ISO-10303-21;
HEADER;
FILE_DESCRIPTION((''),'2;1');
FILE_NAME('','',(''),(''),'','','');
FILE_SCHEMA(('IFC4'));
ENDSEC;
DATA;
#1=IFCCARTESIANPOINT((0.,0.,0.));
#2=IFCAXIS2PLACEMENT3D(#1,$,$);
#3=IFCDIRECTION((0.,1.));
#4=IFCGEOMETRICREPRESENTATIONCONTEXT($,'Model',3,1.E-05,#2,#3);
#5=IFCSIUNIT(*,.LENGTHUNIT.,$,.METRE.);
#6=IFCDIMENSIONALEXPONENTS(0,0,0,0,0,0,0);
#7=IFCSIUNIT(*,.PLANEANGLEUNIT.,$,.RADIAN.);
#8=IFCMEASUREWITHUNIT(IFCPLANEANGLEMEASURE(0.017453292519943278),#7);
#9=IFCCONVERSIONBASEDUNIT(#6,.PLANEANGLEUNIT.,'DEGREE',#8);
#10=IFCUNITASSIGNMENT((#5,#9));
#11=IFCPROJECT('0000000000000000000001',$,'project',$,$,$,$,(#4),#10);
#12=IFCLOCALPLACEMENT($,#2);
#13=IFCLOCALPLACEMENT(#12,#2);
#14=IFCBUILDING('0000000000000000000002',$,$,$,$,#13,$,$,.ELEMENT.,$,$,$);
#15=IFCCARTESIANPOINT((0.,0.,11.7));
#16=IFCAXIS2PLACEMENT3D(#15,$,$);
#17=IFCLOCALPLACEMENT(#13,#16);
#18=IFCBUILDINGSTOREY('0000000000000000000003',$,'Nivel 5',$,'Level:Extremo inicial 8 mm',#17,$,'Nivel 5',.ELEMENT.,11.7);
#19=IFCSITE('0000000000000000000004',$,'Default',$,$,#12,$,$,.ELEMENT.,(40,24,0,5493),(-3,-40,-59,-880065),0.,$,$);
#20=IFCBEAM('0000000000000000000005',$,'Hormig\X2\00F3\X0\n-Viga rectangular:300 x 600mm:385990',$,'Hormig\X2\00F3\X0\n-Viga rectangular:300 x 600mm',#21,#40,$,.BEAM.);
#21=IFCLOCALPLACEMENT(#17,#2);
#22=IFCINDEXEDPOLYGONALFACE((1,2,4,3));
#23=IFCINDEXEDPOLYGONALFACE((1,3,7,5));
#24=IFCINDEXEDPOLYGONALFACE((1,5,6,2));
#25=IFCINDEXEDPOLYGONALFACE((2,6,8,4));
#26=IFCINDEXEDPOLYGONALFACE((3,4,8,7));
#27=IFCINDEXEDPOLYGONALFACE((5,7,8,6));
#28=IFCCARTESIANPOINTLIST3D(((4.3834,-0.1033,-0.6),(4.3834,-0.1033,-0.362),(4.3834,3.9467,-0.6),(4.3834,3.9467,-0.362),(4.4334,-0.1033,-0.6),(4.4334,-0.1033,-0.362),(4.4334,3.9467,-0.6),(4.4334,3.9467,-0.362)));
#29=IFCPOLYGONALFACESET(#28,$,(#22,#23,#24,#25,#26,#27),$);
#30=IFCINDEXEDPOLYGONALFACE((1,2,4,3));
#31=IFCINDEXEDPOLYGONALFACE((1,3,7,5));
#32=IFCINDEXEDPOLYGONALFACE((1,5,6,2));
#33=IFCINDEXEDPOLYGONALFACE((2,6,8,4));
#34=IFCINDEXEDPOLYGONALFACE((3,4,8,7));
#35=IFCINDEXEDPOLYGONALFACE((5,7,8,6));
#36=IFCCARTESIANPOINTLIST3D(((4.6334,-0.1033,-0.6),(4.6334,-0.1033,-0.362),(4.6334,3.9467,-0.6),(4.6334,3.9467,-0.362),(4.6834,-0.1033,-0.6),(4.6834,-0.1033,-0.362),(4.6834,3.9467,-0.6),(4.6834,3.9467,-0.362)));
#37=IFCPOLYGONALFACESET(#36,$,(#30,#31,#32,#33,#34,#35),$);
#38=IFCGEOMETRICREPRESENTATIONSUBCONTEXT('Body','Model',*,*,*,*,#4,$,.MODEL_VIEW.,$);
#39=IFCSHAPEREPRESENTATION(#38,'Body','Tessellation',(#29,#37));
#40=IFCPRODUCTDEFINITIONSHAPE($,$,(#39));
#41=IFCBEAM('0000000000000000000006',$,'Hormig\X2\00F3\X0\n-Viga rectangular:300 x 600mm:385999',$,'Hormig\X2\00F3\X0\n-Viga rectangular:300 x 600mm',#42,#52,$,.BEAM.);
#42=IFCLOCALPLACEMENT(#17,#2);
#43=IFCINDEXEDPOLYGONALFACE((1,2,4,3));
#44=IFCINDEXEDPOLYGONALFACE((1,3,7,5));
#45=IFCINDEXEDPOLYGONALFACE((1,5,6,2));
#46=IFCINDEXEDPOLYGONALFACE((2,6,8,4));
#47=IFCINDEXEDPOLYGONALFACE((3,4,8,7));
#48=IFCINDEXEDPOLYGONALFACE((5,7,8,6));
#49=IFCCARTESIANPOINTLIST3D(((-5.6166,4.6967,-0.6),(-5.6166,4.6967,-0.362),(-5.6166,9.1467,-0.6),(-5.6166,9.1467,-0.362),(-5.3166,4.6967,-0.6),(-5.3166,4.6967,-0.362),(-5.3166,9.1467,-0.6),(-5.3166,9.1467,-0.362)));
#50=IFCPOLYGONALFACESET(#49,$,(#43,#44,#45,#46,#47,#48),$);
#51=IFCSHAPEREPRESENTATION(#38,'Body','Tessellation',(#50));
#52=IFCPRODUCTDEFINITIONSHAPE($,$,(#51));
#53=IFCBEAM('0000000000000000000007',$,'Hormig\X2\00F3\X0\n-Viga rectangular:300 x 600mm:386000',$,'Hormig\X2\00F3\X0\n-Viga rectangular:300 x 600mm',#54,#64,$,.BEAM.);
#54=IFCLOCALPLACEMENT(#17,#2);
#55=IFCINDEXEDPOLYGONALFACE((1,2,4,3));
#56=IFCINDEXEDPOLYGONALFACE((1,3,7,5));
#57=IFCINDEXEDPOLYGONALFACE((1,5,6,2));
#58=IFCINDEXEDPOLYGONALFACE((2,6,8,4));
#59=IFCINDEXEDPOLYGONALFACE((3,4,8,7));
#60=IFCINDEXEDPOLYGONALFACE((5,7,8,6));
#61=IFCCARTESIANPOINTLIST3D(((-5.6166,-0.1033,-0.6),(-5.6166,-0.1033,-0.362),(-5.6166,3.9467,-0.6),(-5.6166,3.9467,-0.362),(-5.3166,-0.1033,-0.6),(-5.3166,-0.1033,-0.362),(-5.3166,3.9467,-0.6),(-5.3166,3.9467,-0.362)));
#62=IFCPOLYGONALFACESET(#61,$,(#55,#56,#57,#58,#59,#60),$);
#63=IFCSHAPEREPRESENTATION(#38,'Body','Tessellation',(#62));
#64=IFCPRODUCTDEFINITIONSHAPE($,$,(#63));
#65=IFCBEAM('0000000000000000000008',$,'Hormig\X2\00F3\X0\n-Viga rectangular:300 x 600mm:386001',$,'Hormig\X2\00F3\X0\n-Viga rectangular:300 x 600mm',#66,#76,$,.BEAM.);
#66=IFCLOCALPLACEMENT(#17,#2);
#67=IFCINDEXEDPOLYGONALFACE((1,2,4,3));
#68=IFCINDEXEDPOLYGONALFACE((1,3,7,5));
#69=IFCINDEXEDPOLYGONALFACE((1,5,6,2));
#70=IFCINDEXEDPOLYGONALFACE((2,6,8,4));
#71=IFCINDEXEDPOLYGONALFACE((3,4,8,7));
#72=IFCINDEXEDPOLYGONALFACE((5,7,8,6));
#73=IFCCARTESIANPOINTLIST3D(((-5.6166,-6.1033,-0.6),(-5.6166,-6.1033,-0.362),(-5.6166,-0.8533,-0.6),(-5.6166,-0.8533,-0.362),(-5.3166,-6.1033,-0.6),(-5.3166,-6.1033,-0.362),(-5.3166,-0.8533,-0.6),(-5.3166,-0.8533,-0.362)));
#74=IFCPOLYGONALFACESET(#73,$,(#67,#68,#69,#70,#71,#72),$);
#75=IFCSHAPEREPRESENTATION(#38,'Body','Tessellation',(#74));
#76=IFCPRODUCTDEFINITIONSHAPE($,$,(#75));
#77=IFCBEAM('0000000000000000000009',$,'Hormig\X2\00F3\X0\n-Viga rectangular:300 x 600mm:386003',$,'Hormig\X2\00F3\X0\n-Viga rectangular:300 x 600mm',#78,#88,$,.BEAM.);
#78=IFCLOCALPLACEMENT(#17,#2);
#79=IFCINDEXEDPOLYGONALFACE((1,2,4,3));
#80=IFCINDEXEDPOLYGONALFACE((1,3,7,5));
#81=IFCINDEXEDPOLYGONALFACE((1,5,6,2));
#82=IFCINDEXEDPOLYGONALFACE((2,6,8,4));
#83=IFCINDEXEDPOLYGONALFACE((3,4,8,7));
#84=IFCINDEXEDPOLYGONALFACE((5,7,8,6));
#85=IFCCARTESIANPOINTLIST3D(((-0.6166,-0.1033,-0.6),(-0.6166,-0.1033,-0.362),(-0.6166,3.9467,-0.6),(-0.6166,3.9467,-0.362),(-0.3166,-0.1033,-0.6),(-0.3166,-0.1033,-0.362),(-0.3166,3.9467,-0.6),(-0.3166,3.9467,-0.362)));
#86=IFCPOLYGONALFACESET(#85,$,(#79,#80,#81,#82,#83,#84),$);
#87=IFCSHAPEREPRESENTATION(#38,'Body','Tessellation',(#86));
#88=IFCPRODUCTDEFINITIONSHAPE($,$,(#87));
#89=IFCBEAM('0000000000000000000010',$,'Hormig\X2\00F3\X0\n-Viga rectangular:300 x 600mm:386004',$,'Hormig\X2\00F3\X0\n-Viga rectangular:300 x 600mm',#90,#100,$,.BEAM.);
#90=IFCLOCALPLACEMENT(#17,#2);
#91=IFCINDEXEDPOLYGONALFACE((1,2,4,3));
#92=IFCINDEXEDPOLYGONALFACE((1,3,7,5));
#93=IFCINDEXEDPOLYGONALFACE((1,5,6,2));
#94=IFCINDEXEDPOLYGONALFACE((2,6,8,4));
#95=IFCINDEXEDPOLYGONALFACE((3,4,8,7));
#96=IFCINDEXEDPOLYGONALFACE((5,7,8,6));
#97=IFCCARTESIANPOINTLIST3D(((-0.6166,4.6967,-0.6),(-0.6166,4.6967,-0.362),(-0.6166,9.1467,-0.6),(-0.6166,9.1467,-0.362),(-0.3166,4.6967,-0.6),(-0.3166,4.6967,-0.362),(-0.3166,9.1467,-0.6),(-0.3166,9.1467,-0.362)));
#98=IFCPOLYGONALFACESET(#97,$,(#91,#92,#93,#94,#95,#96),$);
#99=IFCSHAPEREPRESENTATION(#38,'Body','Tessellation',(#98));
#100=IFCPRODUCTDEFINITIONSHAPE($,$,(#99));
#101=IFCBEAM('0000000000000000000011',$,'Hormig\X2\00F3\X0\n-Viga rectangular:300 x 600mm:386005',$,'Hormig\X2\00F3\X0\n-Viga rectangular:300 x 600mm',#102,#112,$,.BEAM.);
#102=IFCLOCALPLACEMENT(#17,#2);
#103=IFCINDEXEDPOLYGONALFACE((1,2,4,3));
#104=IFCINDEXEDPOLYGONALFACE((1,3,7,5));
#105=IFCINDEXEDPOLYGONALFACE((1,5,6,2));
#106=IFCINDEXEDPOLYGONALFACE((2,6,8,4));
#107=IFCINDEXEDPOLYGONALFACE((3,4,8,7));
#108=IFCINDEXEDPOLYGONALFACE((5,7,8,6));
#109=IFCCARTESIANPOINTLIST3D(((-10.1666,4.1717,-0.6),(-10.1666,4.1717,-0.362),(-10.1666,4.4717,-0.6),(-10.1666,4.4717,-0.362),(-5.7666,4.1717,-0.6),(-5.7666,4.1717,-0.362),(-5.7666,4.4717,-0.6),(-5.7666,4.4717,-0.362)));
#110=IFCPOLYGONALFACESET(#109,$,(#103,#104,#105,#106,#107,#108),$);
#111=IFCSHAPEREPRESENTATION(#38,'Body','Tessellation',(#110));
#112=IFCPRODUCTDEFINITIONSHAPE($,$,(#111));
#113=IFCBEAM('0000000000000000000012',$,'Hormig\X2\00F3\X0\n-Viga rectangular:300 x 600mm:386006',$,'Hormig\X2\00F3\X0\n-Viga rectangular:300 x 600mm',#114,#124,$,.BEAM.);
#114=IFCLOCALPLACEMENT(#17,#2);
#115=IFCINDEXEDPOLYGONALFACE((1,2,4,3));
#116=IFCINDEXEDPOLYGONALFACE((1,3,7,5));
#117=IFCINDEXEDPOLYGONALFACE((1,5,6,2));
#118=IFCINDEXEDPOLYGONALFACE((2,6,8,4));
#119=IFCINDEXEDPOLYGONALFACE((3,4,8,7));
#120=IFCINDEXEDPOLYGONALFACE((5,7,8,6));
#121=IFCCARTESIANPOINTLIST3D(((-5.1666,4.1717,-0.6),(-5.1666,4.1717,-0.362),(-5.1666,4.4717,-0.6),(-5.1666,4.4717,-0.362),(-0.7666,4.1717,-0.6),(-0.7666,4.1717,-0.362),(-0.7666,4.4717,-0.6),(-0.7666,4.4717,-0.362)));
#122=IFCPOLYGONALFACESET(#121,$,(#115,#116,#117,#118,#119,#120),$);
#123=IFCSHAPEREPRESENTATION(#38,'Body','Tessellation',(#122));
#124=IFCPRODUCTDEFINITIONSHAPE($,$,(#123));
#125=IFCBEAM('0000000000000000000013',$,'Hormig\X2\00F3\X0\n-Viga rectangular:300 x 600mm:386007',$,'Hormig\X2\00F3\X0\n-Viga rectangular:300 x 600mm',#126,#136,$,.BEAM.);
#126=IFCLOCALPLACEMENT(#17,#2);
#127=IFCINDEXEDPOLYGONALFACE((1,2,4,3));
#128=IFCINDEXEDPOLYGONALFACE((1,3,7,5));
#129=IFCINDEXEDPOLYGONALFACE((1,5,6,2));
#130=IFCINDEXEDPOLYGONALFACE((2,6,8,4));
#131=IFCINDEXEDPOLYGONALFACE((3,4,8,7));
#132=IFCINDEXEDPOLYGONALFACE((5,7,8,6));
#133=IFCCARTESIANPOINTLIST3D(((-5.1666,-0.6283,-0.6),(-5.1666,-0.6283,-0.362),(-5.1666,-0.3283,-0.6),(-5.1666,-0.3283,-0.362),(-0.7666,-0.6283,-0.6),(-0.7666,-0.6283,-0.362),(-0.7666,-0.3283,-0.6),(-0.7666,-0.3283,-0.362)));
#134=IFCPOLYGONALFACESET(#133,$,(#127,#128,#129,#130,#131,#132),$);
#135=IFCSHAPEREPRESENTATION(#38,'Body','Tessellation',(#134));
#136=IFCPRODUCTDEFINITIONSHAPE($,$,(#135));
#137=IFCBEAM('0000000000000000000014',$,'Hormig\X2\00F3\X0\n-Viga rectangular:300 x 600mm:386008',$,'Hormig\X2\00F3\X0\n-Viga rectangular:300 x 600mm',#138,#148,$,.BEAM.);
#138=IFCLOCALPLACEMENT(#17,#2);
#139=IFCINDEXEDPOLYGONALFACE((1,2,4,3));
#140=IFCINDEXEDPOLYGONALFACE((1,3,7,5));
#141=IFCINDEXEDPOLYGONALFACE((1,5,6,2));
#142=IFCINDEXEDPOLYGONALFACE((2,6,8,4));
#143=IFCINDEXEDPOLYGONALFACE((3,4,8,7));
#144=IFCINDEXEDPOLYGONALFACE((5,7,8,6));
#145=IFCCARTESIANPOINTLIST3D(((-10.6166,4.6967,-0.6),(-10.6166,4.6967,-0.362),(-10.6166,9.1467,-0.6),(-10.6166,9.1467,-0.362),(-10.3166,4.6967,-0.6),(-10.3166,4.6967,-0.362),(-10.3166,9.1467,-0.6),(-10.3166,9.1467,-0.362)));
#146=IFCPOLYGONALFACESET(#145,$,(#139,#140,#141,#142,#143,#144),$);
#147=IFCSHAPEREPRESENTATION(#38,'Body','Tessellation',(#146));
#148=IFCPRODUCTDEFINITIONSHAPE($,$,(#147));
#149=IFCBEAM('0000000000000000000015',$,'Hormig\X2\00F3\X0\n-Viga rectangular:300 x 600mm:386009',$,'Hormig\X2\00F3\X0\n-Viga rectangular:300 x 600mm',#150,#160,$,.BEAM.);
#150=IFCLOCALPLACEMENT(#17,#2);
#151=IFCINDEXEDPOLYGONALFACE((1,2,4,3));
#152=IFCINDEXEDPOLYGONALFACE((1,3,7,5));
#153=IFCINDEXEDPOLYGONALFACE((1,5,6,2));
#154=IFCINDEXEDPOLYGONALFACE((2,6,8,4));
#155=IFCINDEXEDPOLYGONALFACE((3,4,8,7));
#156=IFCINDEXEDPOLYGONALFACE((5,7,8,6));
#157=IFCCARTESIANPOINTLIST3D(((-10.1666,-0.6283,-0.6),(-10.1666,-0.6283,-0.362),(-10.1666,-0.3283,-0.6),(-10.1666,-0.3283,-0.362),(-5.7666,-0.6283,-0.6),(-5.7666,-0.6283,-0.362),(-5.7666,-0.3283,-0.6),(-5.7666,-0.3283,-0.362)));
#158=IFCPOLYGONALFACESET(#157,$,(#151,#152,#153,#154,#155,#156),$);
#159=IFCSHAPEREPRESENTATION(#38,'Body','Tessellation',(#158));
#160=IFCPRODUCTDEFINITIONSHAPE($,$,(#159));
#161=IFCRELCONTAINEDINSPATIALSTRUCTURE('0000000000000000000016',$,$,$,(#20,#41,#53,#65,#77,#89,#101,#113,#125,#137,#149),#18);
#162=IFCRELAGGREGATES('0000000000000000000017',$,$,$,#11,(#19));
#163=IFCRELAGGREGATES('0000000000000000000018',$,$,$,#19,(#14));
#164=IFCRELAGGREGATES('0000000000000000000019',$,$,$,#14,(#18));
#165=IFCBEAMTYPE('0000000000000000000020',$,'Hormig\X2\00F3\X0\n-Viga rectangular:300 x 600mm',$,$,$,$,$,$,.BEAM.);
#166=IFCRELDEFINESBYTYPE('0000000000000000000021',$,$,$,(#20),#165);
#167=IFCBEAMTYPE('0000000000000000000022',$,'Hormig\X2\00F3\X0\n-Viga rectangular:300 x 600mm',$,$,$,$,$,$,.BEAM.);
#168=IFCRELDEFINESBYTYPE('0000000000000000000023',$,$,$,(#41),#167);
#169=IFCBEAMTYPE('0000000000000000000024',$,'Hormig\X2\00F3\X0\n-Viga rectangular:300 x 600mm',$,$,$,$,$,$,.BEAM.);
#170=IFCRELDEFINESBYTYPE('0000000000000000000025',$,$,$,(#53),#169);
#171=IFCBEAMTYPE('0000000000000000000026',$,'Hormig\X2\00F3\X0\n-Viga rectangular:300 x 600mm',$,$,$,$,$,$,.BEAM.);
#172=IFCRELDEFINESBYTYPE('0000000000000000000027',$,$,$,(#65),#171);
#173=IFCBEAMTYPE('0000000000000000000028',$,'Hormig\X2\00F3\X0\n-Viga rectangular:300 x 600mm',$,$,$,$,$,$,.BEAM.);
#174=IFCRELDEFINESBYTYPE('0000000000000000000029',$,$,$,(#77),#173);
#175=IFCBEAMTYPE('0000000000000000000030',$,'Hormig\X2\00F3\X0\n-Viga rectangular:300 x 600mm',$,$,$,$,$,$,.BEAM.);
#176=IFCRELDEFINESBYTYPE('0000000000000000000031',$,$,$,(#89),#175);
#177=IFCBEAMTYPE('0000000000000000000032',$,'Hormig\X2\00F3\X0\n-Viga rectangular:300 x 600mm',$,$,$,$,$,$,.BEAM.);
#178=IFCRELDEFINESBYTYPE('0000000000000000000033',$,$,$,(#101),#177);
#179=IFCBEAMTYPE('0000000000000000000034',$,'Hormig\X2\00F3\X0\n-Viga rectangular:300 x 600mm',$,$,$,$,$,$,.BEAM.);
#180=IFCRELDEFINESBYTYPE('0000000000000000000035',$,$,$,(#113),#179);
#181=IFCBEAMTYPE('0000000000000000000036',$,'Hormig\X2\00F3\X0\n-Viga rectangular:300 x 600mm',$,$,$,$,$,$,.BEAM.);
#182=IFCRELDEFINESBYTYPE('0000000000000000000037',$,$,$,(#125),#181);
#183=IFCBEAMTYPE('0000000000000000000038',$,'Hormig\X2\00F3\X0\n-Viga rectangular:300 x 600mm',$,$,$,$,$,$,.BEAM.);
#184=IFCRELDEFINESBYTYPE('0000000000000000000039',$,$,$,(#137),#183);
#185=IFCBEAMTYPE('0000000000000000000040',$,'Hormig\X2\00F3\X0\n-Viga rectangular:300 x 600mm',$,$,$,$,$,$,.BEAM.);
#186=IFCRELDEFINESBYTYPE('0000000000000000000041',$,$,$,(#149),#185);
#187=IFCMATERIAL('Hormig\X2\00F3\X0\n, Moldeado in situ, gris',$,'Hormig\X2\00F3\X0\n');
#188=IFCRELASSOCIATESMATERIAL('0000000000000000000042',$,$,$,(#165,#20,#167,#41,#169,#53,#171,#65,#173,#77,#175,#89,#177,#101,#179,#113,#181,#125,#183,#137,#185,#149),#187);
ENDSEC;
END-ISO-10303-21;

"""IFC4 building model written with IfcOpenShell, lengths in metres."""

from ifc_helpers import new_model, entity, si_unit, converted_unit, direction, frame, origin, place, context, subcontext, project, spatial, indexed_curve, outline, extrude, source, transform, mapped, material, type_object, type_shapes, element, save


model = new_model("IFC4")

# Units and contexts
model_context = context("Model", 3, precision=1e-05, world=origin(), true_north=direction((0.0, 1.0)))
body_context = subcontext(model_context, "Body", "Model", "MODEL_VIEW")
ifc_project = project(units=[si_unit("LENGTHUNIT", "METRE"), converted_unit("PLANEANGLEUNIT", "DEGREE", entity("IfcPlaneAngleMeasure", 0.017453292519943278), si_unit("PLANEANGLEUNIT", "RADIAN"), dimensions=[0, 0, 0, 0, 0, 0, 0])], contexts=[model_context])

# Site, building, storey
site_placement = place(None, origin())
site = spatial("IfcSite", under=ifc_project, at=site_placement, Name="Default", CompositionType="ELEMENT", RefLatitude=(40, 24, 0, 5493), RefLongitude=(-3, -40, -59, -880065), RefElevation=0.0)
building_placement = place(site_placement, origin())
building = spatial("IfcBuilding", under=site, at=building_placement, CompositionType="ELEMENT")
storey_placement = place(building_placement, frame((0.0, 0.0, 11.7)))
storey = spatial("IfcBuildingStorey", under=building, at=storey_placement, Name="Nivel 5", ObjectType="Level:Extremo inicial 8 mm", LongName="Nivel 5", CompositionType="ELEMENT", Elevation=11.7)

# Shared definitions
ifc_material_1 = material(Name="Hormigón, Moldeado in situ, gris", Category="Hormigón")

# Beams
beam_type_1 = type_object("IfcBeamType", Name="Hormigón-Viga rectangular:300 x 600mm", PredefinedType="BEAM", material=ifc_material_1)
shared_shape_1 = source(origin(), body_context, "Body", "SweptSolid", [
    extrude(outline(indexed_curve([(-0.025, -0.119), (0.025, -0.119), (0.025, 0.119), (-0.025, 0.119), (-0.025, -0.119)], self_intersect=False)), frame((4.4084, 3.9467, 11.219), z_axis=(0.0, -1.0, 0.0), x_axis=(-1.0, 0.0, 0.0)), (0.0, 0.0, 1.0), 4.05),
    extrude(outline(indexed_curve([(-0.025, -0.119), (0.025, -0.119), (0.025, 0.119), (-0.025, 0.119), (-0.025, -0.119)], self_intersect=False)), frame((4.6584, 3.9467, 11.219), z_axis=(0.0, -1.0, 0.0), x_axis=(-1.0, 0.0, 0.0)), (0.0, 0.0, 1.0), 4.05),
])
type_shapes(beam_type_1, [shared_shape_1])
beam_1_placement = place(storey_placement, frame((0.0, 0.0, -11.7)))
element("IfcBeam", 1, at=beam_1_placement, inside=storey, type_object=beam_type_1, material=ifc_material_1, Name="Hormigón-Viga rectangular:300 x 600mm:385990", ObjectType="Hormigón-Viga rectangular:300 x 600mm", PredefinedType="BEAM", context=body_context, shape_type="MappedRepresentation", body=[
    mapped(shared_shape_1, transform((0.0, 0.0, 0.0), scale=1.0)),
])
beam_type_2 = type_object("IfcBeamType", Name="Hormigón-Viga rectangular:300 x 600mm", PredefinedType="BEAM", material=ifc_material_1)
shared_shape_2 = source(origin(), body_context, "Body", "SweptSolid", [
    extrude(outline(indexed_curve([(-0.15, -0.119), (0.15, -0.119), (0.15, 0.119), (-0.15, 0.119), (-0.15, -0.119)], self_intersect=False)), frame((-5.4666, 9.1467, 11.219), z_axis=(0.0, -1.0, 0.0), x_axis=(-1.0, 0.0, 0.0)), (0.0, 0.0, 1.0), 4.45),
])
type_shapes(beam_type_2, [shared_shape_2])
beam_2_placement = place(storey_placement, frame((0.0, 0.0, -11.7)))
element("IfcBeam", 2, at=beam_2_placement, inside=storey, type_object=beam_type_2, material=ifc_material_1, Name="Hormigón-Viga rectangular:300 x 600mm:385999", ObjectType="Hormigón-Viga rectangular:300 x 600mm", PredefinedType="BEAM", context=body_context, shape_type="MappedRepresentation", body=[
    mapped(shared_shape_2, transform((0.0, 0.0, 0.0), scale=1.0)),
])
beam_type_3 = type_object("IfcBeamType", Name="Hormigón-Viga rectangular:300 x 600mm", PredefinedType="BEAM", material=ifc_material_1)
shared_shape_3 = source(origin(), body_context, "Body", "SweptSolid", [
    extrude(outline(indexed_curve([(-0.15, -0.119), (0.15, -0.119), (0.15, 0.119), (-0.15, 0.119), (-0.15, -0.119)], self_intersect=False)), frame((-5.4666, 3.9467, 11.219), z_axis=(0.0, -1.0, 0.0), x_axis=(-1.0, 0.0, 0.0)), (0.0, 0.0, 1.0), 4.05),
])
type_shapes(beam_type_3, [shared_shape_3])
beam_3_placement = place(storey_placement, frame((0.0, 0.0, -11.7)))
element("IfcBeam", 3, at=beam_3_placement, inside=storey, type_object=beam_type_3, material=ifc_material_1, Name="Hormigón-Viga rectangular:300 x 600mm:386000", ObjectType="Hormigón-Viga rectangular:300 x 600mm", PredefinedType="BEAM", context=body_context, shape_type="MappedRepresentation", body=[
    mapped(shared_shape_3, transform((0.0, 0.0, 0.0), scale=1.0)),
])
beam_type_4 = type_object("IfcBeamType", Name="Hormigón-Viga rectangular:300 x 600mm", PredefinedType="BEAM", material=ifc_material_1)
shared_shape_4 = source(origin(), body_context, "Body", "SweptSolid", [
    extrude(outline(indexed_curve([(-0.15, -0.119), (0.15, -0.119), (0.15, 0.119), (-0.15, 0.119), (-0.15, -0.119)], self_intersect=False)), frame((-5.4666, -6.1033, 11.219), z_axis=(0.0, 1.0, 0.0), x_axis=(-1.0, 0.0, 0.0)), (0.0, 0.0, 1.0), 5.25),
])
type_shapes(beam_type_4, [shared_shape_4])
beam_4_placement = place(storey_placement, frame((0.0, 0.0, -11.7)))
element("IfcBeam", 4, at=beam_4_placement, inside=storey, type_object=beam_type_4, material=ifc_material_1, Name="Hormigón-Viga rectangular:300 x 600mm:386001", ObjectType="Hormigón-Viga rectangular:300 x 600mm", PredefinedType="BEAM", context=body_context, shape_type="MappedRepresentation", body=[
    mapped(shared_shape_4, transform((0.0, 0.0, 0.0), scale=1.0)),
])
beam_type_5 = type_object("IfcBeamType", Name="Hormigón-Viga rectangular:300 x 600mm", PredefinedType="BEAM", material=ifc_material_1)
shared_shape_5 = source(origin(), body_context, "Body", "SweptSolid", [
    extrude(outline(indexed_curve([(-0.15, -0.119), (0.15, -0.119), (0.15, 0.119), (-0.15, 0.119), (-0.15, -0.119)], self_intersect=False)), frame((-0.4666, -0.1033, 11.219), z_axis=(0.0, 1.0, 0.0), x_axis=(-1.0, 0.0, 0.0)), (0.0, 0.0, 1.0), 4.05),
])
type_shapes(beam_type_5, [shared_shape_5])
beam_5_placement = place(storey_placement, frame((0.0, 0.0, -11.7)))
element("IfcBeam", 5, at=beam_5_placement, inside=storey, type_object=beam_type_5, material=ifc_material_1, Name="Hormigón-Viga rectangular:300 x 600mm:386003", ObjectType="Hormigón-Viga rectangular:300 x 600mm", PredefinedType="BEAM", context=body_context, shape_type="MappedRepresentation", body=[
    mapped(shared_shape_5, transform((0.0, 0.0, 0.0), scale=1.0)),
])
beam_type_6 = type_object("IfcBeamType", Name="Hormigón-Viga rectangular:300 x 600mm", PredefinedType="BEAM", material=ifc_material_1)
shared_shape_6 = source(origin(), body_context, "Body", "SweptSolid", [
    extrude(outline(indexed_curve([(-0.15, -0.119), (0.15, -0.119), (0.15, 0.119), (-0.15, 0.119), (-0.15, -0.119)], self_intersect=False)), frame((-0.4666, 9.1467, 11.219), z_axis=(0.0, -1.0, 0.0), x_axis=(-1.0, 0.0, 0.0)), (0.0, 0.0, 1.0), 4.45),
])
type_shapes(beam_type_6, [shared_shape_6])
beam_6_placement = place(storey_placement, frame((0.0, 0.0, -11.7)))
element("IfcBeam", 6, at=beam_6_placement, inside=storey, type_object=beam_type_6, material=ifc_material_1, Name="Hormigón-Viga rectangular:300 x 600mm:386004", ObjectType="Hormigón-Viga rectangular:300 x 600mm", PredefinedType="BEAM", context=body_context, shape_type="MappedRepresentation", body=[
    mapped(shared_shape_6, transform((0.0, 0.0, 0.0), scale=1.0)),
])
beam_type_7 = type_object("IfcBeamType", Name="Hormigón-Viga rectangular:300 x 600mm", PredefinedType="BEAM", material=ifc_material_1)
shared_shape_7 = source(origin(), body_context, "Body", "SweptSolid", [
    extrude(outline(indexed_curve([(-0.119, -0.15), (0.119, -0.15), (0.119, 0.15), (-0.119, 0.15), (-0.119, -0.15)], self_intersect=False)), frame((-10.1666, 4.3217, 11.219), z_axis=(1.0, 0.0, 0.0), x_axis=(0.0, 0.0, -1.0)), (0.0, 0.0, 1.0), 4.4),
])
type_shapes(beam_type_7, [shared_shape_7])
beam_7_placement = place(storey_placement, frame((0.0, 0.0, -11.7)))
element("IfcBeam", 7, at=beam_7_placement, inside=storey, type_object=beam_type_7, material=ifc_material_1, Name="Hormigón-Viga rectangular:300 x 600mm:386005", ObjectType="Hormigón-Viga rectangular:300 x 600mm", PredefinedType="BEAM", context=body_context, shape_type="MappedRepresentation", body=[
    mapped(shared_shape_7, transform((0.0, 0.0, 0.0), scale=1.0)),
])
beam_type_8 = type_object("IfcBeamType", Name="Hormigón-Viga rectangular:300 x 600mm", PredefinedType="BEAM", material=ifc_material_1)
shared_shape_8 = source(origin(), body_context, "Body", "SweptSolid", [
    extrude(outline(indexed_curve([(-0.119, -0.15), (0.119, -0.15), (0.119, 0.15), (-0.119, 0.15), (-0.119, -0.15)], self_intersect=False)), frame((-5.1666, 4.3217, 11.219), z_axis=(1.0, 0.0, 0.0), x_axis=(0.0, 0.0, -1.0)), (0.0, 0.0, 1.0), 4.4),
])
type_shapes(beam_type_8, [shared_shape_8])
beam_8_placement = place(storey_placement, frame((0.0, 0.0, -11.7)))
element("IfcBeam", 8, at=beam_8_placement, inside=storey, type_object=beam_type_8, material=ifc_material_1, Name="Hormigón-Viga rectangular:300 x 600mm:386006", ObjectType="Hormigón-Viga rectangular:300 x 600mm", PredefinedType="BEAM", context=body_context, shape_type="MappedRepresentation", body=[
    mapped(shared_shape_8, transform((0.0, 0.0, 0.0), scale=1.0)),
])
beam_type_9 = type_object("IfcBeamType", Name="Hormigón-Viga rectangular:300 x 600mm", PredefinedType="BEAM", material=ifc_material_1)
shared_shape_9 = source(origin(), body_context, "Body", "SweptSolid", [
    extrude(outline(indexed_curve([(-0.119, -0.15), (0.119, -0.15), (0.119, 0.15), (-0.119, 0.15), (-0.119, -0.15)], self_intersect=False)), frame((-0.7666, -0.4783, 11.219), z_axis=(-1.0, 0.0, 0.0), x_axis=(0.0, 0.0, -1.0)), (0.0, 0.0, 1.0), 4.4),
])
type_shapes(beam_type_9, [shared_shape_9])
beam_9_placement = place(storey_placement, frame((0.0, 0.0, -11.7)))
element("IfcBeam", 9, at=beam_9_placement, inside=storey, type_object=beam_type_9, material=ifc_material_1, Name="Hormigón-Viga rectangular:300 x 600mm:386007", ObjectType="Hormigón-Viga rectangular:300 x 600mm", PredefinedType="BEAM", context=body_context, shape_type="MappedRepresentation", body=[
    mapped(shared_shape_9, transform((0.0, 0.0, 0.0), scale=1.0)),
])
beam_type_10 = type_object("IfcBeamType", Name="Hormigón-Viga rectangular:300 x 600mm", PredefinedType="BEAM", material=ifc_material_1)
shared_shape_10 = source(origin(), body_context, "Body", "SweptSolid", [
    extrude(outline(indexed_curve([(-0.15, -0.119), (0.15, -0.119), (0.15, 0.119), (-0.15, 0.119), (-0.15, -0.119)], self_intersect=False)), frame((-10.4666, 4.6967, 11.219), z_axis=(0.0, 1.0, 0.0), x_axis=(-1.0, 0.0, 0.0)), (0.0, 0.0, 1.0), 4.45),
])
type_shapes(beam_type_10, [shared_shape_10])
beam_10_placement = place(storey_placement, frame((0.0, 0.0, -11.7)))
element("IfcBeam", 10, at=beam_10_placement, inside=storey, type_object=beam_type_10, material=ifc_material_1, Name="Hormigón-Viga rectangular:300 x 600mm:386008", ObjectType="Hormigón-Viga rectangular:300 x 600mm", PredefinedType="BEAM", context=body_context, shape_type="MappedRepresentation", body=[
    mapped(shared_shape_10, transform((0.0, 0.0, 0.0), scale=1.0)),
])
beam_type_11 = type_object("IfcBeamType", Name="Hormigón-Viga rectangular:300 x 600mm", PredefinedType="BEAM", material=ifc_material_1)
shared_shape_11 = source(origin(), body_context, "Body", "SweptSolid", [
    extrude(outline(indexed_curve([(-0.119, -0.15), (0.119, -0.15), (0.119, 0.15), (-0.119, 0.15), (-0.119, -0.15)], self_intersect=False)), frame((-10.1666, -0.4783, 11.219), z_axis=(1.0, 0.0, 0.0), x_axis=(0.0, 0.0, -1.0)), (0.0, 0.0, 1.0), 4.4),
])
type_shapes(beam_type_11, [shared_shape_11])
beam_11_placement = place(storey_placement, frame((0.0, 0.0, -11.7)))
element("IfcBeam", 11, at=beam_11_placement, inside=storey, type_object=beam_type_11, material=ifc_material_1, Name="Hormigón-Viga rectangular:300 x 600mm:386009", ObjectType="Hormigón-Viga rectangular:300 x 600mm", PredefinedType="BEAM", context=body_context, shape_type="MappedRepresentation", body=[
    mapped(shared_shape_11, transform((0.0, 0.0, 0.0), scale=1.0)),
])

save(model, "model.ifc")
